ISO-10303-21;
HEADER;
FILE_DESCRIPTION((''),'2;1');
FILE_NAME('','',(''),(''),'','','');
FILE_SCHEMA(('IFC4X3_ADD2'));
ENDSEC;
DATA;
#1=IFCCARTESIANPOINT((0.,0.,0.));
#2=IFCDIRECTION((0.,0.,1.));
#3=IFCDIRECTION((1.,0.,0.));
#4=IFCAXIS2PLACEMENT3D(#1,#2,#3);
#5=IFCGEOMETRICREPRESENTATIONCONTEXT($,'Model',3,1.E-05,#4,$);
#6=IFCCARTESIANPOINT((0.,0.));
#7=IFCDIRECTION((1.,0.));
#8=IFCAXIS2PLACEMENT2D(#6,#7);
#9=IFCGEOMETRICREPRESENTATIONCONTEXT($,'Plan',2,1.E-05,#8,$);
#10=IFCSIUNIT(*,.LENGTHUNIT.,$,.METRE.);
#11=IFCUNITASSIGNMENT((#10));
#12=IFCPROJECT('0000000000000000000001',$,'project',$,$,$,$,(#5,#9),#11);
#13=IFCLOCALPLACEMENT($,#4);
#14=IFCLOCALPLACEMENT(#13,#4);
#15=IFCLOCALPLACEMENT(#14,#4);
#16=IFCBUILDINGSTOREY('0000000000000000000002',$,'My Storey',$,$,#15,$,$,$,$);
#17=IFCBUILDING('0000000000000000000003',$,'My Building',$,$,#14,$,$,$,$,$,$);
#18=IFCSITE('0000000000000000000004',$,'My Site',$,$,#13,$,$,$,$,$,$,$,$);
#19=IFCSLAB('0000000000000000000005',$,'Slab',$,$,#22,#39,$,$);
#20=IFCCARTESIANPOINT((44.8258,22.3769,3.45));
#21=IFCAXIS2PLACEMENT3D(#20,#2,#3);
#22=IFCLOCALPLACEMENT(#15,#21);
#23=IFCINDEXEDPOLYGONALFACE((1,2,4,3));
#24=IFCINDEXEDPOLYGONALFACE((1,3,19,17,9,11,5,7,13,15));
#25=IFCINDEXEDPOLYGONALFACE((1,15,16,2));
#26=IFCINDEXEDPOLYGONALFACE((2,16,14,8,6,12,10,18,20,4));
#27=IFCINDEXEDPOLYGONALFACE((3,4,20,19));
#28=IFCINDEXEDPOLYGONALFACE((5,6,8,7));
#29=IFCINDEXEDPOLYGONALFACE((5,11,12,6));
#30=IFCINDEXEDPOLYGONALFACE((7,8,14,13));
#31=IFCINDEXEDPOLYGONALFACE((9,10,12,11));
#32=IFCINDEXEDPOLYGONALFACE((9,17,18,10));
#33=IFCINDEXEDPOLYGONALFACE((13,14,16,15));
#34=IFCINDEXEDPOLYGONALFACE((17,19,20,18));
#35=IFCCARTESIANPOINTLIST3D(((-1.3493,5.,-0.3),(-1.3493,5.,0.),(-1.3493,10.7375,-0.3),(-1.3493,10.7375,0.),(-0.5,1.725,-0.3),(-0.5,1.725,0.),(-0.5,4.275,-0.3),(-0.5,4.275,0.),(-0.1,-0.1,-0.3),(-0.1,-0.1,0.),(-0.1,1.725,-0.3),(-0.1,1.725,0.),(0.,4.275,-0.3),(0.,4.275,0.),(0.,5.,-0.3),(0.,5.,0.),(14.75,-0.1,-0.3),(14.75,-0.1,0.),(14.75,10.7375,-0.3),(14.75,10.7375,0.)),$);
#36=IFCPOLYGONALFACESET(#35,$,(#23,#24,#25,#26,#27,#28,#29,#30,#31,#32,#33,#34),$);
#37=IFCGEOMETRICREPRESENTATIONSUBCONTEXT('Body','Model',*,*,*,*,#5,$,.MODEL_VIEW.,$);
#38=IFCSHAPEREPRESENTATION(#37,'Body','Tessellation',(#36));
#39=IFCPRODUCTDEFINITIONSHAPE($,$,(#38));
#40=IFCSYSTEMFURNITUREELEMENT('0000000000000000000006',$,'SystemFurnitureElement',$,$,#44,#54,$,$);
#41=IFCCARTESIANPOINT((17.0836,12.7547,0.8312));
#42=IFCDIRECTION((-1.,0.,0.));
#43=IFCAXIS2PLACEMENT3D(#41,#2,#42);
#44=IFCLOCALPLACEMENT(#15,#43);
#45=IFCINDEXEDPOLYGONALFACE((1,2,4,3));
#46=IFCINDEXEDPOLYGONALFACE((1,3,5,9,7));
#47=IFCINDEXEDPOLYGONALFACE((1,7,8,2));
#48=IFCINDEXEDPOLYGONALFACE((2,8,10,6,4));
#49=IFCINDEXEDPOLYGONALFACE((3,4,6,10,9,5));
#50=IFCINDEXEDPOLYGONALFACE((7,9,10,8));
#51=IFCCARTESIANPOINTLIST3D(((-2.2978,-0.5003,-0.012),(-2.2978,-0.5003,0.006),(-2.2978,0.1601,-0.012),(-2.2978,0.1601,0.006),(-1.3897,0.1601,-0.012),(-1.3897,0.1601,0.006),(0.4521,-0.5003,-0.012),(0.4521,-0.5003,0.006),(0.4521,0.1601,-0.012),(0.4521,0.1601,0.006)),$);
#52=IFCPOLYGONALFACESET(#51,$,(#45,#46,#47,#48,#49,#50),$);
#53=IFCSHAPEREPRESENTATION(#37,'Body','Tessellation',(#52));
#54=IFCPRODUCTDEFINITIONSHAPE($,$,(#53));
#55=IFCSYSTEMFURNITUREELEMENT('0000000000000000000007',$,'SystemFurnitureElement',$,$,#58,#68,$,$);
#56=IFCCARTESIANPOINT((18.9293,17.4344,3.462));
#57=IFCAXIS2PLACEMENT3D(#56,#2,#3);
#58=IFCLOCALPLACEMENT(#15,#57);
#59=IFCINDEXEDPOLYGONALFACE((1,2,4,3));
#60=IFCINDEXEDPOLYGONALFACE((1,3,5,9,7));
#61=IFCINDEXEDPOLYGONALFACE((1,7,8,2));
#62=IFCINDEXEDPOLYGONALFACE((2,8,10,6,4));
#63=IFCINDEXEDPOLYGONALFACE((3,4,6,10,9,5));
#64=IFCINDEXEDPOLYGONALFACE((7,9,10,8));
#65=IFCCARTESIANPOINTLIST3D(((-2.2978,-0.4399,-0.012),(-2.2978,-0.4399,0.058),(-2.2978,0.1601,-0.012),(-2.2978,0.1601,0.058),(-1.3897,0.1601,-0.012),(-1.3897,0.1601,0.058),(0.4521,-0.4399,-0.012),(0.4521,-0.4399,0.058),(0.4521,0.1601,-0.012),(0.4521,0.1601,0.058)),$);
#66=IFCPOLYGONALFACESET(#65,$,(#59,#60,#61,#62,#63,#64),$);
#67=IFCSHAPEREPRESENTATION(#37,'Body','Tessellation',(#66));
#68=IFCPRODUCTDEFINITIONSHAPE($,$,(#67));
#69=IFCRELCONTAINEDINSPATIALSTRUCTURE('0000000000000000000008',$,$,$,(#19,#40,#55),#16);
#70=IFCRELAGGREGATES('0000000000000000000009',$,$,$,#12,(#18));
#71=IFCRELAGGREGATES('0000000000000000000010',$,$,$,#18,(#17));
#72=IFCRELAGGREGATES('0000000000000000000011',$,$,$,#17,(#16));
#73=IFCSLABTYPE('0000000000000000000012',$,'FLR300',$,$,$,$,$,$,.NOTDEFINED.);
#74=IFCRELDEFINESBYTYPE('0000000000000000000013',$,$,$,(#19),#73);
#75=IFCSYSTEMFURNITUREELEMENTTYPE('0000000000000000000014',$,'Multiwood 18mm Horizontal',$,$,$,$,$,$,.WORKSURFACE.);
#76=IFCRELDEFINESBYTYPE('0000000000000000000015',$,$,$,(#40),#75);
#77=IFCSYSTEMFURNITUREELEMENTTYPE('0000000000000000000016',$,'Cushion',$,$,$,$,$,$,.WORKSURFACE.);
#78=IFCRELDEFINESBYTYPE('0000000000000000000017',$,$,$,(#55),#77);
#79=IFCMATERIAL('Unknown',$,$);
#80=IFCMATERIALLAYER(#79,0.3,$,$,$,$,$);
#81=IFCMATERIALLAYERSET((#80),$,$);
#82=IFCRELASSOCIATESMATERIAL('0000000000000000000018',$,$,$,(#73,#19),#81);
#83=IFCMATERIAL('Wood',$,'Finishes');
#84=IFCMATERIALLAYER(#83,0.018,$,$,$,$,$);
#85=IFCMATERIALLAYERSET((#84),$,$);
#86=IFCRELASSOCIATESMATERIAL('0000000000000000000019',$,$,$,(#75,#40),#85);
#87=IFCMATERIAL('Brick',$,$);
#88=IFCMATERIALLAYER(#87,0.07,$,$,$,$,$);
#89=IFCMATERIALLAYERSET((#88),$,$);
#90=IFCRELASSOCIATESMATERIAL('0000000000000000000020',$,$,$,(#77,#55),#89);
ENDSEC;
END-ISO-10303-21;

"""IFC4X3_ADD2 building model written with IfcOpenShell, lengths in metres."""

from ifc_helpers import new_model, si_unit, frame, origin_with_axes, origin_2d_with_axis, place, context, subcontext, project, spatial, indexed_curve, outline, extrude, material, layer, layer_set, layer_usage, type_object, element, save


model = new_model("IFC4X3_ADD2")

# Units and contexts
model_context = context("Model", 3, precision=1e-05, world=origin_with_axes())
plan_context = context("Plan", 2, precision=1e-05, world=origin_2d_with_axis())
body_context = subcontext(model_context, "Body", "Model", "MODEL_VIEW")
ifc_project = project(units=[si_unit("LENGTHUNIT", "METRE")], contexts=[model_context, plan_context])

# Site, building, storey
site_placement = place(None, origin_with_axes())
site = spatial("IfcSite", under=ifc_project, at=site_placement, Name="My Site")
building_placement = place(site_placement, origin_with_axes())
building = spatial("IfcBuilding", under=site, at=building_placement, Name="My Building")
storey_placement = place(building_placement, origin_with_axes())
storey = spatial("IfcBuildingStorey", under=building, at=storey_placement, Name="My Storey")

# Slab
ifc_material_1 = material(Name="Unknown")
ifc_layer_1 = layer(ifc_material_1, 0.3)
ifc_layer_set_1 = layer_set([ifc_layer_1])
ifc_layer_usage_1 = layer_usage(ifc_layer_set_1, "AXIS3", "POSITIVE", -0.3)
slab_type = type_object("IfcSlabType", Name="FLR300", PredefinedType="NOTDEFINED", material=ifc_layer_set_1)
slab_placement = place(storey_placement, frame((44.8258, 22.3769, 3.45), z_axis=(0.0, 0.0, 1.0), x_axis=(1.0, 0.0, 0.0)))
element("IfcSlab", 1, at=slab_placement, inside=storey, type_object=slab_type, material=ifc_layer_usage_1, Name="Slab", context=body_context, shape_type="SweptSolid", body=[
    extrude(outline(indexed_curve([(-0.1, -0.1), (-0.1, 1.725), (-0.5, 1.725), (-0.5, 4.275), (0.0, 4.275), (0.0, 5.0), (-1.3493, 5.0), (-1.3493, 10.7375), (14.75, 10.7375), (14.75, -0.1), (-0.1, -0.1)])), frame((0.0, 0.0, -0.3), z_axis=(0.0, 0.0, 1.0), x_axis=(1.0, 0.0, 0.0)), (0.0, 0.0, 1.0), 0.3),
])

# Shared definitions
ifc_material_2 = material(Name="Brick")

# System furniture elements
ifc_material_3 = material(Name="Wood", Category="Finishes")
ifc_layer_2 = layer(ifc_material_3, 0.018)
ifc_layer_set_2 = layer_set([ifc_layer_2])
ifc_layer_usage_2 = layer_usage(ifc_layer_set_2, "AXIS3", "POSITIVE", -0.012)
system_furniture_element_type_1 = type_object("IfcSystemFurnitureElementType", Name="Multiwood 18mm Horizontal", PredefinedType="WORKSURFACE", material=ifc_layer_set_2)
system_furniture_element_1_placement = place(storey_placement, frame((17.0836, 12.7547, 0.8312), z_axis=(0.0, 0.0, 1.0), x_axis=(-1.0, 0.0, 0.0)))
element("IfcSystemFurnitureElement", 2, at=system_furniture_element_1_placement, inside=storey, type_object=system_furniture_element_type_1, material=ifc_layer_usage_2, Name="SystemFurnitureElement", context=body_context, shape_type="SweptSolid", body=[
    extrude(outline(indexed_curve([(-2.2978, -0.5003), (-2.2978, 0.1601), (-1.3897, 0.1601), (0.4521, 0.1601), (0.4521, -0.5003), (-2.2978, -0.5003)])), frame((0.0, 0.0, -0.012), z_axis=(0.0, 0.0, 1.0), x_axis=(1.0, 0.0, 0.0)), (0.0, 0.0, 1.0), 0.018),
])
ifc_layer_3 = layer(ifc_material_2, 0.07)
ifc_layer_set_3 = layer_set([ifc_layer_3])
ifc_layer_usage_3 = layer_usage(ifc_layer_set_3, "AXIS3", "POSITIVE", -0.012)
system_furniture_element_type_2 = type_object("IfcSystemFurnitureElementType", Name="Cushion", PredefinedType="WORKSURFACE", material=ifc_layer_set_3)
system_furniture_element_2_placement = place(storey_placement, frame((18.9293, 17.4344, 3.462), z_axis=(0.0, 0.0, 1.0), x_axis=(1.0, 0.0, 0.0)))
element("IfcSystemFurnitureElement", 3, at=system_furniture_element_2_placement, inside=storey, type_object=system_furniture_element_type_2, material=ifc_layer_usage_3, Name="SystemFurnitureElement", context=body_context, shape_type="SweptSolid", body=[
    extrude(outline(indexed_curve([(0.4521, -0.4399), (0.4521, 0.1601), (-1.3897, 0.1601), (-2.2978, 0.1601), (-2.2978, -0.4399), (0.4521, -0.4399)])), frame((0.0, 0.0, -0.012), z_axis=(0.0, 0.0, 1.0), x_axis=(1.0, 0.0, 0.0)), (0.0, 0.0, 1.0), 0.07),
])

save(model, "model.ifc")
